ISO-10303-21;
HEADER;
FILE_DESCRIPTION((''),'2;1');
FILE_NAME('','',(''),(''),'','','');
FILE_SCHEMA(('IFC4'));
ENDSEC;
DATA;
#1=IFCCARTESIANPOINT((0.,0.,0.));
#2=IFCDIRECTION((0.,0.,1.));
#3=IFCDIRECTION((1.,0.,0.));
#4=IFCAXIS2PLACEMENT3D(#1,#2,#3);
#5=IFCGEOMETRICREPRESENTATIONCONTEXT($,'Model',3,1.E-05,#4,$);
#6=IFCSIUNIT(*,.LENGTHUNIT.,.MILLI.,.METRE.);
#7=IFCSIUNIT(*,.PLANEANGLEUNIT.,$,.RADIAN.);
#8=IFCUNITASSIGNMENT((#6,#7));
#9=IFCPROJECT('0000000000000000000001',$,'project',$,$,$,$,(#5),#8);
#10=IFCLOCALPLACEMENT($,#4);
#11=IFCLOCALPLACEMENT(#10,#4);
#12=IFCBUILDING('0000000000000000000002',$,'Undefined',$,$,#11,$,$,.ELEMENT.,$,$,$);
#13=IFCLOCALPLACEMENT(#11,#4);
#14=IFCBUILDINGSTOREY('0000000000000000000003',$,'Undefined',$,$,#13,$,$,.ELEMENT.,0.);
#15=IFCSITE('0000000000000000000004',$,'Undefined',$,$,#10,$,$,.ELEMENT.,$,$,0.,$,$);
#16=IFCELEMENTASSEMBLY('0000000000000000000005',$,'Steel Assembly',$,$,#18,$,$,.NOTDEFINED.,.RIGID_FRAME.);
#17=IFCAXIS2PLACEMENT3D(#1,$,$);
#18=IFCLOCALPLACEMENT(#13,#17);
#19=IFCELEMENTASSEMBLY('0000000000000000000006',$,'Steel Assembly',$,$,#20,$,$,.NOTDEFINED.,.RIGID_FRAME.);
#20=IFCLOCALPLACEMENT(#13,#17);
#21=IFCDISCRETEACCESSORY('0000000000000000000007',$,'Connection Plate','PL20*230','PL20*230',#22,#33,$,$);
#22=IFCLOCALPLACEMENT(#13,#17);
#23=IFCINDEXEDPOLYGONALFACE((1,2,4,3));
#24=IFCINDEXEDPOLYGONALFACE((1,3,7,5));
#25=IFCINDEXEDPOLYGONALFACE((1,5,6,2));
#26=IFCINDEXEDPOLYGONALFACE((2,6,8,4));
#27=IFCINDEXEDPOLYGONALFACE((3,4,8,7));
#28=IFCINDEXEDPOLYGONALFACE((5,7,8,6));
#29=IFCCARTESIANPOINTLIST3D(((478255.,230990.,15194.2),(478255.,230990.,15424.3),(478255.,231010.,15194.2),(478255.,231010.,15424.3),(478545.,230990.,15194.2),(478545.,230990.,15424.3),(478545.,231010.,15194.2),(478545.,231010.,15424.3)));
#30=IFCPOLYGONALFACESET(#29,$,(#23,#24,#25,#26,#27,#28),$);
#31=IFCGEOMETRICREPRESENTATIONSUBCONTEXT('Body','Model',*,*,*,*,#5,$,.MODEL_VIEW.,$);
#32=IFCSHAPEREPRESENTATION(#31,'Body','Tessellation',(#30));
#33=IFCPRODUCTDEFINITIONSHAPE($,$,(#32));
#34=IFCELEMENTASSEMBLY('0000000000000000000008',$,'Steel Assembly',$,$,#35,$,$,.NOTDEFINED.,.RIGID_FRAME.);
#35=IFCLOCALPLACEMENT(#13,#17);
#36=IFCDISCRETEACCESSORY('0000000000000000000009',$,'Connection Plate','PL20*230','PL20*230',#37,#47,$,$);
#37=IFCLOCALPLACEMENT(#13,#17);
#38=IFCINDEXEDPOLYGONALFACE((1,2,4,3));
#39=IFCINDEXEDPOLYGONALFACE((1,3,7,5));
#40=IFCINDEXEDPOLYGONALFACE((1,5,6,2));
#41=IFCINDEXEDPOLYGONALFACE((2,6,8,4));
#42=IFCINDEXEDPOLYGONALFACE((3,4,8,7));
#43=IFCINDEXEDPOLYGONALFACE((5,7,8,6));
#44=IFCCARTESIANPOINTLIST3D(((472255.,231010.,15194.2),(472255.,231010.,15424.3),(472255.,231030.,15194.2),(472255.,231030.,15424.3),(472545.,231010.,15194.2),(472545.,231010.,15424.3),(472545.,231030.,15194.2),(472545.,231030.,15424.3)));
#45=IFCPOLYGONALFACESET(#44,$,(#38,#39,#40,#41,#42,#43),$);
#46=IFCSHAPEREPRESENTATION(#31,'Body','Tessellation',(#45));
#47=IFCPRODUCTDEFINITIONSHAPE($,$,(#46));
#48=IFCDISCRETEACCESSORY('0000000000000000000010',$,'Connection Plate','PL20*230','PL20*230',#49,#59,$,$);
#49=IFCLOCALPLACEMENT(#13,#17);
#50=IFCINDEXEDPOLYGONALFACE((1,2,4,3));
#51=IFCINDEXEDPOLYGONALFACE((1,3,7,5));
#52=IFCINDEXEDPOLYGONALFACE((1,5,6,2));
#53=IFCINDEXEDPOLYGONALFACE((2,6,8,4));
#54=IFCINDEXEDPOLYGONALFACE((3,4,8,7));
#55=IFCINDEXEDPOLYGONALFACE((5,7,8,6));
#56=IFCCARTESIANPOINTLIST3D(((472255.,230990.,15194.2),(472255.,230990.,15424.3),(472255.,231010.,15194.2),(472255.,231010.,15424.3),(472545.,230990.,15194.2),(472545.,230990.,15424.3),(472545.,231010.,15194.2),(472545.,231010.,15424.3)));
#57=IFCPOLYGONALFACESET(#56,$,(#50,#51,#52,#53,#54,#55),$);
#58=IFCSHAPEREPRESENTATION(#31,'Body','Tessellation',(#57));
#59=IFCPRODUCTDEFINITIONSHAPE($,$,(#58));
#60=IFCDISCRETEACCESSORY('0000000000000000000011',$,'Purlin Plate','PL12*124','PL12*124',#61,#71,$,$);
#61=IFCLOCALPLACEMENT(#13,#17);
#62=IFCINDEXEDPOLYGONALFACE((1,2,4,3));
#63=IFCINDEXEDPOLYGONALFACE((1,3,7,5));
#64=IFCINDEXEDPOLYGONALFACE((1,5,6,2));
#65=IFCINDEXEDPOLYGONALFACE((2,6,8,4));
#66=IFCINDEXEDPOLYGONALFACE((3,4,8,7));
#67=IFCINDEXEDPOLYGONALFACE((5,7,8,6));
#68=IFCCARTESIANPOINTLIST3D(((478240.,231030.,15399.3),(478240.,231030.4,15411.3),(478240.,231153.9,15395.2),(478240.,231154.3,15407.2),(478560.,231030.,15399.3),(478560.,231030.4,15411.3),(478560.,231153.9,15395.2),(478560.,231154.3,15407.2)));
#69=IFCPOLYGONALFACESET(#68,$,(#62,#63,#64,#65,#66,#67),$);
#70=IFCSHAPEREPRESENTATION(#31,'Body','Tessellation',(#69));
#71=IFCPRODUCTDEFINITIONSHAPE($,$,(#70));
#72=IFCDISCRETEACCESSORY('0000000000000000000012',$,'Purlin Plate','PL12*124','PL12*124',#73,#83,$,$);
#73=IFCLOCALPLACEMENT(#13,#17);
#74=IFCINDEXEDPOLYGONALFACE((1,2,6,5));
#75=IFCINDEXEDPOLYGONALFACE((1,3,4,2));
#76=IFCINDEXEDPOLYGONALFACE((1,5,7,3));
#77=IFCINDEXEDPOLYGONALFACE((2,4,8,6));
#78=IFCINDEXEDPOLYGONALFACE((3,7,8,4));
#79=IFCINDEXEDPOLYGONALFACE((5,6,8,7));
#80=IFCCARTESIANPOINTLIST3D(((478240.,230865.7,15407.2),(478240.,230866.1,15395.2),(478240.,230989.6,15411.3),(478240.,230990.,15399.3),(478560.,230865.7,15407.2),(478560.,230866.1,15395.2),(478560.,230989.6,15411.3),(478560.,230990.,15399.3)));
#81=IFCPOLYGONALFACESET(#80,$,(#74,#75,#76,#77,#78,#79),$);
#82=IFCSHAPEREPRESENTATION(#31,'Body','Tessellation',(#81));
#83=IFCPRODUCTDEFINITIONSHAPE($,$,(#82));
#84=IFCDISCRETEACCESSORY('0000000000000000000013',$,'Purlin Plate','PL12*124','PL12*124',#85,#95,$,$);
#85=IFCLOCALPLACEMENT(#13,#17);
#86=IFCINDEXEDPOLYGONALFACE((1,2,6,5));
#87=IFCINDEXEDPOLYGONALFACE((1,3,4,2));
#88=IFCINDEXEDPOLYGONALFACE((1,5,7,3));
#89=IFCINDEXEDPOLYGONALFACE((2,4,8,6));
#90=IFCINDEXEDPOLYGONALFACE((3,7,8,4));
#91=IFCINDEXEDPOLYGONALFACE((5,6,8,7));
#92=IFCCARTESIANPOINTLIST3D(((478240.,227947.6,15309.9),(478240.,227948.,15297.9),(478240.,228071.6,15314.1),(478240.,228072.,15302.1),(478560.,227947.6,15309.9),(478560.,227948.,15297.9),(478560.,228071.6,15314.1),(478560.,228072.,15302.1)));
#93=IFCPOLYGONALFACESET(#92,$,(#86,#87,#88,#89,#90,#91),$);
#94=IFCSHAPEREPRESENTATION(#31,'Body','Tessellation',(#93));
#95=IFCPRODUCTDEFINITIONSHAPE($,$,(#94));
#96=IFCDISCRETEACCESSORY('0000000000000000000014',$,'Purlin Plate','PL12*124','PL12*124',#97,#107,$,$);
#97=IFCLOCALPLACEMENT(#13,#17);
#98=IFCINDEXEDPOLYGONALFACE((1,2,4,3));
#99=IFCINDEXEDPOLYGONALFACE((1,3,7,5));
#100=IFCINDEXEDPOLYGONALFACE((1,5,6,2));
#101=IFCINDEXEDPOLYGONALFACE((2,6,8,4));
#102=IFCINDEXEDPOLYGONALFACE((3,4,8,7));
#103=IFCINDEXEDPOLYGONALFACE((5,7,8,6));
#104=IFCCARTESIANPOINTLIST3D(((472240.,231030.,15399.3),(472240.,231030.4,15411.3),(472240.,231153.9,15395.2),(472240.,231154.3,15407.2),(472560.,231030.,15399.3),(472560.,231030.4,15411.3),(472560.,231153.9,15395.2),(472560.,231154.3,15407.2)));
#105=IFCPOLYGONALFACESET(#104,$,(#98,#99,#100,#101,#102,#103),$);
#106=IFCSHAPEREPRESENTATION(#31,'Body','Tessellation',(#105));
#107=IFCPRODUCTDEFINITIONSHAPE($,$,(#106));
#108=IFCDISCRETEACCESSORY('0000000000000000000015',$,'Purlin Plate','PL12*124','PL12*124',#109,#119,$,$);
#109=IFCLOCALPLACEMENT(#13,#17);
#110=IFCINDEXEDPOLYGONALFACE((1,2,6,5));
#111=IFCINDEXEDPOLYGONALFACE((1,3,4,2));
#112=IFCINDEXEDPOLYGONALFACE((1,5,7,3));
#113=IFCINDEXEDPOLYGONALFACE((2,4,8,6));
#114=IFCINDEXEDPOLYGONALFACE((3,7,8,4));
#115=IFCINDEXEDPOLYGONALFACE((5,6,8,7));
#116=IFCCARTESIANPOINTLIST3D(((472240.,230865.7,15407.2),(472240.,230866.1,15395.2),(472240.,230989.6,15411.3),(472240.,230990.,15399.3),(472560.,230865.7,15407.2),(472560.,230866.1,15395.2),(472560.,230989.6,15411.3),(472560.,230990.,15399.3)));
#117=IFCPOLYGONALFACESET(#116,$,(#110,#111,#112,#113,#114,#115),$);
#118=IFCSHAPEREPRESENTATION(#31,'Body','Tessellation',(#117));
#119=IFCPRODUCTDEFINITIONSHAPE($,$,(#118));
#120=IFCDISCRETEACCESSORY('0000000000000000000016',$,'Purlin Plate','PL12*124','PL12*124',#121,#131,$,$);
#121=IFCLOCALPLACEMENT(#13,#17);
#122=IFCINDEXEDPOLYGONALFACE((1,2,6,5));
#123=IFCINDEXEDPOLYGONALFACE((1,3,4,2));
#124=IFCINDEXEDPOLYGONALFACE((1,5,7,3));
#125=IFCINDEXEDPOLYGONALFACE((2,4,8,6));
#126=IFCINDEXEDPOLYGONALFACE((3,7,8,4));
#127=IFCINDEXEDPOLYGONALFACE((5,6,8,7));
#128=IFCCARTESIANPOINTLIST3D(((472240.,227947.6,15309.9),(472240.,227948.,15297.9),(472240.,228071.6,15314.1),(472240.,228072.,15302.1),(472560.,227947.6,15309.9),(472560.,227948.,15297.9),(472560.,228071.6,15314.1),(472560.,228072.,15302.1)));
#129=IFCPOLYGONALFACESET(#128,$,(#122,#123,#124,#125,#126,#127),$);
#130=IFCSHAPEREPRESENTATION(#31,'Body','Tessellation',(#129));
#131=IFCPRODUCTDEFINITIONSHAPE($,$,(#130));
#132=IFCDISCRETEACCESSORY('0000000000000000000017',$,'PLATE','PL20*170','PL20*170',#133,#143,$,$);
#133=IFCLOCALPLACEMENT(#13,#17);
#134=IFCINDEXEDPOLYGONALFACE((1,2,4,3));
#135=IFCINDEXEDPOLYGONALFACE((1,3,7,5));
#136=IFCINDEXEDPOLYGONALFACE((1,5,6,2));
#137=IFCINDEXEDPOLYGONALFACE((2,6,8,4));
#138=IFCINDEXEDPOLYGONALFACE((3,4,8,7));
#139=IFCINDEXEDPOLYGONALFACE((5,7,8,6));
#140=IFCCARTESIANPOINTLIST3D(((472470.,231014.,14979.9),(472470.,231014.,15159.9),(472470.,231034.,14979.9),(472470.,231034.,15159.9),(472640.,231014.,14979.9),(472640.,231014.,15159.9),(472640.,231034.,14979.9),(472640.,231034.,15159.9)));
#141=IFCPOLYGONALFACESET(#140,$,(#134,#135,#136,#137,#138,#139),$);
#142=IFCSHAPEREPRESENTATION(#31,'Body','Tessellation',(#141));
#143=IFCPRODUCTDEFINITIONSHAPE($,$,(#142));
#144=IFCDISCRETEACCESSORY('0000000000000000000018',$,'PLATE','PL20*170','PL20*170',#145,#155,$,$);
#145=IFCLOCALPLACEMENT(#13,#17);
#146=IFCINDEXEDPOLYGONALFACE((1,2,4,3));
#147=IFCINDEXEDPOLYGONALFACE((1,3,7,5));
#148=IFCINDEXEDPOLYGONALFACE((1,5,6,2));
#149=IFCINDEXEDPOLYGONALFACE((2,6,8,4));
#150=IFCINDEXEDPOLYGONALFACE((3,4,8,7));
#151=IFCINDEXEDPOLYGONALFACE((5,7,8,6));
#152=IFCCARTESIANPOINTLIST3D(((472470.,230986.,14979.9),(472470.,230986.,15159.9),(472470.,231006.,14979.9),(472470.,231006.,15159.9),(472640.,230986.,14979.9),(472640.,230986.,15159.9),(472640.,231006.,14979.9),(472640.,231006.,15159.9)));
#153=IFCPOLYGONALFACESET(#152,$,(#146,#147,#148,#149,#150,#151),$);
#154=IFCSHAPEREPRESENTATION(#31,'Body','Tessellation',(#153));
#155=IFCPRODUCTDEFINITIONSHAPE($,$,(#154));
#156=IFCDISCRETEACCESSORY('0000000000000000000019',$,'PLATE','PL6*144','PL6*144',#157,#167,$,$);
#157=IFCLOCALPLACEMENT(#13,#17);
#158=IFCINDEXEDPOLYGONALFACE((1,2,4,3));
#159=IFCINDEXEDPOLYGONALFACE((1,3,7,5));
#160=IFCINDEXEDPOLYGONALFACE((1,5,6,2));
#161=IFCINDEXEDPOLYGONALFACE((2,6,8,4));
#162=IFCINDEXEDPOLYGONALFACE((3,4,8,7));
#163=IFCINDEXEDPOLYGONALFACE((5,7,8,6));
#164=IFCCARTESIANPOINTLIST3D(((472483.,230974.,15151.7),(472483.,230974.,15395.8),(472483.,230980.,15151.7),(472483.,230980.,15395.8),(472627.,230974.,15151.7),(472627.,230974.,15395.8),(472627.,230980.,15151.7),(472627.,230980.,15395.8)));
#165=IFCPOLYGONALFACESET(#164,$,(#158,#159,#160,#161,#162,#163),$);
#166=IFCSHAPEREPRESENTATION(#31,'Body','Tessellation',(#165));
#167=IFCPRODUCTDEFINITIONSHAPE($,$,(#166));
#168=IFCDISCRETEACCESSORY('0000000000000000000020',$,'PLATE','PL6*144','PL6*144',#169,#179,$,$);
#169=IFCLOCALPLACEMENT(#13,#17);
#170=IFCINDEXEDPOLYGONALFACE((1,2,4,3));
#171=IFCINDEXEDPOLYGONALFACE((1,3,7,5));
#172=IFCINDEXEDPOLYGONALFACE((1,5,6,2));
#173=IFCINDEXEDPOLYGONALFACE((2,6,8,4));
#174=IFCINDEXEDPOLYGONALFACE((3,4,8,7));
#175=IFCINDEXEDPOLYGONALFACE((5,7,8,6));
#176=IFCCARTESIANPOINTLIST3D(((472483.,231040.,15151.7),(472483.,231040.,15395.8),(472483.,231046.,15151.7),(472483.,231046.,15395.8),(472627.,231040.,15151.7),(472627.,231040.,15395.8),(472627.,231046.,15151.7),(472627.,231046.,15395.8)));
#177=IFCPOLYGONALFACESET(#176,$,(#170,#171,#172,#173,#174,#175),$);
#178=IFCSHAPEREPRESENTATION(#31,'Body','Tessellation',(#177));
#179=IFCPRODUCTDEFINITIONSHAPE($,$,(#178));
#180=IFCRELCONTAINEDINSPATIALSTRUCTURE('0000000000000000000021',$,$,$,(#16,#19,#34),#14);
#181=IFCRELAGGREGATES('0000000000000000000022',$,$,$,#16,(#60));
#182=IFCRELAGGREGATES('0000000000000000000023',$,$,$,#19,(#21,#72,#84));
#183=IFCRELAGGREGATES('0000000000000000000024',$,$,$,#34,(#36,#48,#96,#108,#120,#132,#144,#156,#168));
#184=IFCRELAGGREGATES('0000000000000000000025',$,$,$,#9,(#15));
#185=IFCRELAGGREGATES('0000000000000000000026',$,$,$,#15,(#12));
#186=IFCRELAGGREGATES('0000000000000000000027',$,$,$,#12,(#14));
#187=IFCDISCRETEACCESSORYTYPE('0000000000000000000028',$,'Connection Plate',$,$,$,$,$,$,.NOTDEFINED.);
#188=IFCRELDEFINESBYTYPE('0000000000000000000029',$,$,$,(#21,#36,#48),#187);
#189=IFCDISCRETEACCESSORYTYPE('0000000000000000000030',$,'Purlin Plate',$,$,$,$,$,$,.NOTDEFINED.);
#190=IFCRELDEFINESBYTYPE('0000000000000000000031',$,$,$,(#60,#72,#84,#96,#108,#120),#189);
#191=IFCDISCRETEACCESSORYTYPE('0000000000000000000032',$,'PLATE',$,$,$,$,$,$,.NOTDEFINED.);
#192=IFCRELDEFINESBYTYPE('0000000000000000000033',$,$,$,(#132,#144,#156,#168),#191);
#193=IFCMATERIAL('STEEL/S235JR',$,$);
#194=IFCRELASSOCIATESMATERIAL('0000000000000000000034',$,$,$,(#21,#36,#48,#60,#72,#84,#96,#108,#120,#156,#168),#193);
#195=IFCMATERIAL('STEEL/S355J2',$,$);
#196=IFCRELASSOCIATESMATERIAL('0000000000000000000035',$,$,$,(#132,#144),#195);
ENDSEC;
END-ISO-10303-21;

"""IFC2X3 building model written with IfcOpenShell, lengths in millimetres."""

from ifc_helpers import new_model, si_unit, frame, origin_with_axes, origin_2d_with_axis, place, context, subcontext, project, spatial, polyline, rectangle, outline, extrude, material, type_object, element, aggregate, save


model = new_model("IFC2X3")

# Units and contexts
model_context = context("Model", 3, precision=1e-05, world=origin_with_axes())
body_context = subcontext(model_context, "Body", "Model", "MODEL_VIEW")
ifc_project = project(units=[si_unit("LENGTHUNIT", "METRE", prefix="MILLI"), si_unit("PLANEANGLEUNIT", "RADIAN")], contexts=[model_context])

# Site, building, storey
site_placement = place(None, origin_with_axes())
site = spatial("IfcSite", under=ifc_project, at=site_placement, Name="Undefined", CompositionType="ELEMENT", RefElevation=0.0)
building_placement = place(site_placement, origin_with_axes())
building = spatial("IfcBuilding", under=site, at=building_placement, Name="Undefined", CompositionType="ELEMENT")
storey_placement = place(building_placement, origin_with_axes())
storey = spatial("IfcBuildingStorey", under=building, at=storey_placement, Name="Undefined", CompositionType="ELEMENT", Elevation=0.0)

# Shared definitions
ifc_material_1 = material(Name="STEEL/S355J2")

# Element assemblies, discrete accessory
assembly_1_placement = place(storey_placement, origin_with_axes())
assembly_1 = element("IfcElementAssembly", 1, at=assembly_1_placement, inside=storey, Name="Steel Assembly", AssemblyPlace="NOTDEFINED", PredefinedType="RIGID_FRAME")
ifc_material_2 = material(Name="STEEL/S235JR")
discrete_accessory_type_1 = type_object("IfcDiscreteAccessoryType", Name="Connection Plate")
assembly_2_placement = place(storey_placement, origin_with_axes())
assembly_2 = element("IfcElementAssembly", 2, at=assembly_2_placement, inside=storey, Name="Steel Assembly", AssemblyPlace="NOTDEFINED", PredefinedType="RIGID_FRAME")
discrete_accessory_1_placement = place(assembly_2_placement, frame((478545.0, 231000.0, 15424.3), z_axis=(0.0, -1.0, 0.0), x_axis=(-1.0, 0.0, 0.0)))
discrete_accessory_1 = element("IfcDiscreteAccessory", 3, at=discrete_accessory_1_placement, type_object=discrete_accessory_type_1, material=ifc_material_2, Name="Connection Plate", Description="PL20*230", ObjectType="PL20*230", context=body_context, shape_type="SweptSolid", body=[
    extrude(outline(polyline([(0.0, 0.0), (290.0, 0.0), (290.0, 230.1), (0.0, 230.1), (0.0, 0.0)])), frame((0.0, 0.0, -10.0), z_axis=(0.0, 0.0, 1.0), x_axis=(1.0, 0.0, 0.0)), (0.0, 0.0, 1.0), 20.0),
])

# Element assembly, discrete accessories
assembly_3_placement = place(storey_placement, origin_with_axes())
assembly_3 = element("IfcElementAssembly", 4, at=assembly_3_placement, inside=storey, Name="Steel Assembly", AssemblyPlace="NOTDEFINED", PredefinedType="RIGID_FRAME")
discrete_accessory_2_placement = place(assembly_3_placement, frame((472545.0, 231020.0, 15424.3), z_axis=(0.0, -1.0, 0.0), x_axis=(-1.0, 0.0, 0.0)))
discrete_accessory_2 = element("IfcDiscreteAccessory", 5, at=discrete_accessory_2_placement, type_object=discrete_accessory_type_1, material=ifc_material_2, Name="Connection Plate", Description="PL20*230", ObjectType="PL20*230", context=body_context, shape_type="SweptSolid", body=[
    extrude(outline(polyline([(0.0, 0.0), (290.0, 0.0), (290.0, 230.1), (0.0, 230.1), (0.0, 0.0)])), frame((0.0, 0.0, -10.0), z_axis=(0.0, 0.0, 1.0), x_axis=(1.0, 0.0, 0.0)), (0.0, 0.0, 1.0), 20.0),
])
discrete_accessory_3_placement = place(assembly_3_placement, frame((472545.0, 231000.0, 15424.3), z_axis=(0.0, -1.0, 0.0), x_axis=(-1.0, 0.0, 0.0)))
discrete_accessory_3 = element("IfcDiscreteAccessory", 6, at=discrete_accessory_3_placement, type_object=discrete_accessory_type_1, material=ifc_material_2, Name="Connection Plate", Description="PL20*230", ObjectType="PL20*230", context=body_context, shape_type="SweptSolid", body=[
    extrude(outline(polyline([(0.0, 0.0), (290.0, 0.0), (290.0, 230.1), (0.0, 230.1), (0.0, 0.0)])), frame((0.0, 0.0, -10.0), z_axis=(0.0, 0.0, 1.0), x_axis=(1.0, 0.0, 0.0)), (0.0, 0.0, 1.0), 20.0),
])

# Discrete accessories
discrete_accessory_type_2 = type_object("IfcDiscreteAccessoryType", Name="Purlin Plate")
discrete_accessory_4_placement = place(assembly_1_placement, frame((478560.0, 231154.1, 15401.2), z_axis=(0.0, -0.033315, -0.999445), x_axis=(0.0, -0.999445, 0.033315)))
discrete_accessory_4 = element("IfcDiscreteAccessory", 7, at=discrete_accessory_4_placement, type_object=discrete_accessory_type_2, material=ifc_material_2, Name="Purlin Plate", Description="PL12*124", ObjectType="PL12*124", context=body_context, shape_type="SweptSolid", body=[
    extrude(outline(polyline([(0.0, 0.0), (124.0, 0.0), (124.0, 320.0), (0.0, 320.0), (0.0, 0.0)])), frame((0.0, 0.0, -6.0), z_axis=(0.0, 0.0, 1.0), x_axis=(1.0, 0.0, 0.0)), (0.0, 0.0, 1.0), 12.0),
])
aggregate(assembly_1, [discrete_accessory_4])
discrete_accessory_5_placement = place(assembly_2_placement, frame((478560.0, 230865.9, 15401.2), z_axis=(0.0, -0.033315, 0.999445), x_axis=(0.0, 0.999445, 0.033315)))
discrete_accessory_5 = element("IfcDiscreteAccessory", 8, at=discrete_accessory_5_placement, type_object=discrete_accessory_type_2, material=ifc_material_2, Name="Purlin Plate", Description="PL12*124", ObjectType="PL12*124", context=body_context, shape_type="SweptSolid", body=[
    extrude(outline(polyline([(0.0, 0.0), (124.0, 0.0), (124.0, 320.0), (0.0, 320.0), (0.0, 0.0)])), frame((0.0, 0.0, -6.0), z_axis=(0.0, 0.0, 1.0), x_axis=(1.0, 0.0, 0.0)), (0.0, 0.0, 1.0), 12.0),
])
discrete_accessory_6_placement = place(assembly_2_placement, frame((478560.0, 227947.8, 15303.9), z_axis=(0.0, -0.033315, 0.999445), x_axis=(0.0, 0.999445, 0.033315)))
discrete_accessory_6 = element("IfcDiscreteAccessory", 9, at=discrete_accessory_6_placement, type_object=discrete_accessory_type_2, material=ifc_material_2, Name="Purlin Plate", Description="PL12*124", ObjectType="PL12*124", context=body_context, shape_type="SweptSolid", body=[
    extrude(outline(polyline([(0.0, 0.0), (124.0, 0.0), (124.0, 320.0), (0.0, 320.0), (0.0, 0.0)])), frame((0.0, 0.0, -6.0), z_axis=(0.0, 0.0, 1.0), x_axis=(1.0, 0.0, 0.0)), (0.0, 0.0, 1.0), 12.0),
])
aggregate(assembly_2, [discrete_accessory_1, discrete_accessory_5, discrete_accessory_6])
discrete_accessory_7_placement = place(assembly_3_placement, frame((472560.0, 231154.1, 15401.2), z_axis=(0.0, -0.033315, -0.999445), x_axis=(0.0, -0.999445, 0.033315)))
discrete_accessory_7 = element("IfcDiscreteAccessory", 10, at=discrete_accessory_7_placement, type_object=discrete_accessory_type_2, material=ifc_material_2, Name="Purlin Plate", Description="PL12*124", ObjectType="PL12*124", context=body_context, shape_type="SweptSolid", body=[
    extrude(outline(polyline([(0.0, 0.0), (124.0, 0.0), (124.0, 320.0), (0.0, 320.0), (0.0, 0.0)])), frame((0.0, 0.0, -6.0), z_axis=(0.0, 0.0, 1.0), x_axis=(1.0, 0.0, 0.0)), (0.0, 0.0, 1.0), 12.0),
])
discrete_accessory_8_placement = place(assembly_3_placement, frame((472560.0, 230865.9, 15401.2), z_axis=(0.0, -0.033315, 0.999445), x_axis=(0.0, 0.999445, 0.033315)))
discrete_accessory_8 = element("IfcDiscreteAccessory", 11, at=discrete_accessory_8_placement, type_object=discrete_accessory_type_2, material=ifc_material_2, Name="Purlin Plate", Description="PL12*124", ObjectType="PL12*124", context=body_context, shape_type="SweptSolid", body=[
    extrude(outline(polyline([(0.0, 0.0), (124.0, 0.0), (124.0, 320.0), (0.0, 320.0), (0.0, 0.0)])), frame((0.0, 0.0, -6.0), z_axis=(0.0, 0.0, 1.0), x_axis=(1.0, 0.0, 0.0)), (0.0, 0.0, 1.0), 12.0),
])
discrete_accessory_9_placement = place(assembly_3_placement, frame((472560.0, 227947.8, 15303.9), z_axis=(0.0, -0.033315, 0.999445), x_axis=(0.0, 0.999445, 0.033315)))
discrete_accessory_9 = element("IfcDiscreteAccessory", 12, at=discrete_accessory_9_placement, type_object=discrete_accessory_type_2, material=ifc_material_2, Name="Purlin Plate", Description="PL12*124", ObjectType="PL12*124", context=body_context, shape_type="SweptSolid", body=[
    extrude(outline(polyline([(0.0, 0.0), (124.0, 0.0), (124.0, 320.0), (0.0, 320.0), (0.0, 0.0)])), frame((0.0, 0.0, -6.0), z_axis=(0.0, 0.0, 1.0), x_axis=(1.0, 0.0, 0.0)), (0.0, 0.0, 1.0), 12.0),
])
discrete_accessory_type_3 = type_object("IfcDiscreteAccessoryType", Name="PLATE")
discrete_accessory_10_placement = place(assembly_3_placement, frame((472470.0, 231024.0, 14979.9), z_axis=(0.0, 1.0, 0.0), x_axis=(0.0, 0.0, 1.0)))
discrete_accessory_10 = element("IfcDiscreteAccessory", 13, at=discrete_accessory_10_placement, type_object=discrete_accessory_type_3, material=ifc_material_1, Name="PLATE", Description="PL20*170", ObjectType="PL20*170", context=body_context, shape_type="SweptSolid", body=[
    extrude(outline(polyline([(0.0, 0.0), (180.0, 0.0), (180.0, 170.0), (0.0, 170.0), (0.0, 0.0)])), frame((0.0, 0.0, -10.0), z_axis=(0.0, 0.0, 1.0), x_axis=(1.0, 0.0, 0.0)), (0.0, 0.0, 1.0), 20.0),
])
discrete_accessory_11_placement = place(assembly_3_placement, frame((472470.0, 230996.0, 14979.9), z_axis=(0.0, 1.0, 0.0), x_axis=(0.0, 0.0, 1.0)))
discrete_accessory_11 = element("IfcDiscreteAccessory", 14, at=discrete_accessory_11_placement, type_object=discrete_accessory_type_3, material=ifc_material_1, Name="PLATE", Description="PL20*170", ObjectType="PL20*170", context=body_context, shape_type="SweptSolid", body=[
    extrude(outline(polyline([(0.0, 0.0), (180.0, 0.0), (180.0, 170.0), (0.0, 170.0), (0.0, 0.0)])), frame((0.0, 0.0, -10.0), z_axis=(0.0, 0.0, 1.0), x_axis=(1.0, 0.0, 0.0)), (0.0, 0.0, 1.0), 20.0),
])
discrete_accessory_12_placement = place(assembly_3_placement, frame((472555.0, 230977.0, 15151.7), z_axis=(0.0, 0.0, 1.0), x_axis=(1.0, 0.0, 0.0)))
discrete_accessory_12 = element("IfcDiscreteAccessory", 15, at=discrete_accessory_12_placement, type_object=discrete_accessory_type_3, material=ifc_material_2, Name="PLATE", Description="PL6*144", ObjectType="PL6*144", context=body_context, shape_type="SweptSolid", body=[
    extrude(rectangle(XDim=6.0, YDim=144.0, at=origin_2d_with_axis()), frame((0.0, 0.0, 244.1), z_axis=(0.0, 0.0, -1.0), x_axis=(0.0, -1.0, 0.0)), (0.0, 0.0, 1.0), 244.1),
])
discrete_accessory_13_placement = place(assembly_3_placement, frame((472555.0, 231043.0, 15151.7), z_axis=(0.0, 0.0, 1.0), x_axis=(1.0, 0.0, 0.0)))
discrete_accessory_13 = element("IfcDiscreteAccessory", 16, at=discrete_accessory_13_placement, type_object=discrete_accessory_type_3, material=ifc_material_2, Name="PLATE", Description="PL6*144", ObjectType="PL6*144", context=body_context, shape_type="SweptSolid", body=[
    extrude(rectangle(XDim=6.0, YDim=144.0, at=origin_2d_with_axis()), frame((0.0, 0.0, 244.1), z_axis=(0.0, 0.0, -1.0), x_axis=(0.0, 1.0, 0.0)), (0.0, 0.0, 1.0), 244.1),
])
aggregate(assembly_3, [discrete_accessory_2, discrete_accessory_3, discrete_accessory_7, discrete_accessory_8, discrete_accessory_9, discrete_accessory_10, discrete_accessory_11, discrete_accessory_12, discrete_accessory_13])

save(model, "model.ifc")
